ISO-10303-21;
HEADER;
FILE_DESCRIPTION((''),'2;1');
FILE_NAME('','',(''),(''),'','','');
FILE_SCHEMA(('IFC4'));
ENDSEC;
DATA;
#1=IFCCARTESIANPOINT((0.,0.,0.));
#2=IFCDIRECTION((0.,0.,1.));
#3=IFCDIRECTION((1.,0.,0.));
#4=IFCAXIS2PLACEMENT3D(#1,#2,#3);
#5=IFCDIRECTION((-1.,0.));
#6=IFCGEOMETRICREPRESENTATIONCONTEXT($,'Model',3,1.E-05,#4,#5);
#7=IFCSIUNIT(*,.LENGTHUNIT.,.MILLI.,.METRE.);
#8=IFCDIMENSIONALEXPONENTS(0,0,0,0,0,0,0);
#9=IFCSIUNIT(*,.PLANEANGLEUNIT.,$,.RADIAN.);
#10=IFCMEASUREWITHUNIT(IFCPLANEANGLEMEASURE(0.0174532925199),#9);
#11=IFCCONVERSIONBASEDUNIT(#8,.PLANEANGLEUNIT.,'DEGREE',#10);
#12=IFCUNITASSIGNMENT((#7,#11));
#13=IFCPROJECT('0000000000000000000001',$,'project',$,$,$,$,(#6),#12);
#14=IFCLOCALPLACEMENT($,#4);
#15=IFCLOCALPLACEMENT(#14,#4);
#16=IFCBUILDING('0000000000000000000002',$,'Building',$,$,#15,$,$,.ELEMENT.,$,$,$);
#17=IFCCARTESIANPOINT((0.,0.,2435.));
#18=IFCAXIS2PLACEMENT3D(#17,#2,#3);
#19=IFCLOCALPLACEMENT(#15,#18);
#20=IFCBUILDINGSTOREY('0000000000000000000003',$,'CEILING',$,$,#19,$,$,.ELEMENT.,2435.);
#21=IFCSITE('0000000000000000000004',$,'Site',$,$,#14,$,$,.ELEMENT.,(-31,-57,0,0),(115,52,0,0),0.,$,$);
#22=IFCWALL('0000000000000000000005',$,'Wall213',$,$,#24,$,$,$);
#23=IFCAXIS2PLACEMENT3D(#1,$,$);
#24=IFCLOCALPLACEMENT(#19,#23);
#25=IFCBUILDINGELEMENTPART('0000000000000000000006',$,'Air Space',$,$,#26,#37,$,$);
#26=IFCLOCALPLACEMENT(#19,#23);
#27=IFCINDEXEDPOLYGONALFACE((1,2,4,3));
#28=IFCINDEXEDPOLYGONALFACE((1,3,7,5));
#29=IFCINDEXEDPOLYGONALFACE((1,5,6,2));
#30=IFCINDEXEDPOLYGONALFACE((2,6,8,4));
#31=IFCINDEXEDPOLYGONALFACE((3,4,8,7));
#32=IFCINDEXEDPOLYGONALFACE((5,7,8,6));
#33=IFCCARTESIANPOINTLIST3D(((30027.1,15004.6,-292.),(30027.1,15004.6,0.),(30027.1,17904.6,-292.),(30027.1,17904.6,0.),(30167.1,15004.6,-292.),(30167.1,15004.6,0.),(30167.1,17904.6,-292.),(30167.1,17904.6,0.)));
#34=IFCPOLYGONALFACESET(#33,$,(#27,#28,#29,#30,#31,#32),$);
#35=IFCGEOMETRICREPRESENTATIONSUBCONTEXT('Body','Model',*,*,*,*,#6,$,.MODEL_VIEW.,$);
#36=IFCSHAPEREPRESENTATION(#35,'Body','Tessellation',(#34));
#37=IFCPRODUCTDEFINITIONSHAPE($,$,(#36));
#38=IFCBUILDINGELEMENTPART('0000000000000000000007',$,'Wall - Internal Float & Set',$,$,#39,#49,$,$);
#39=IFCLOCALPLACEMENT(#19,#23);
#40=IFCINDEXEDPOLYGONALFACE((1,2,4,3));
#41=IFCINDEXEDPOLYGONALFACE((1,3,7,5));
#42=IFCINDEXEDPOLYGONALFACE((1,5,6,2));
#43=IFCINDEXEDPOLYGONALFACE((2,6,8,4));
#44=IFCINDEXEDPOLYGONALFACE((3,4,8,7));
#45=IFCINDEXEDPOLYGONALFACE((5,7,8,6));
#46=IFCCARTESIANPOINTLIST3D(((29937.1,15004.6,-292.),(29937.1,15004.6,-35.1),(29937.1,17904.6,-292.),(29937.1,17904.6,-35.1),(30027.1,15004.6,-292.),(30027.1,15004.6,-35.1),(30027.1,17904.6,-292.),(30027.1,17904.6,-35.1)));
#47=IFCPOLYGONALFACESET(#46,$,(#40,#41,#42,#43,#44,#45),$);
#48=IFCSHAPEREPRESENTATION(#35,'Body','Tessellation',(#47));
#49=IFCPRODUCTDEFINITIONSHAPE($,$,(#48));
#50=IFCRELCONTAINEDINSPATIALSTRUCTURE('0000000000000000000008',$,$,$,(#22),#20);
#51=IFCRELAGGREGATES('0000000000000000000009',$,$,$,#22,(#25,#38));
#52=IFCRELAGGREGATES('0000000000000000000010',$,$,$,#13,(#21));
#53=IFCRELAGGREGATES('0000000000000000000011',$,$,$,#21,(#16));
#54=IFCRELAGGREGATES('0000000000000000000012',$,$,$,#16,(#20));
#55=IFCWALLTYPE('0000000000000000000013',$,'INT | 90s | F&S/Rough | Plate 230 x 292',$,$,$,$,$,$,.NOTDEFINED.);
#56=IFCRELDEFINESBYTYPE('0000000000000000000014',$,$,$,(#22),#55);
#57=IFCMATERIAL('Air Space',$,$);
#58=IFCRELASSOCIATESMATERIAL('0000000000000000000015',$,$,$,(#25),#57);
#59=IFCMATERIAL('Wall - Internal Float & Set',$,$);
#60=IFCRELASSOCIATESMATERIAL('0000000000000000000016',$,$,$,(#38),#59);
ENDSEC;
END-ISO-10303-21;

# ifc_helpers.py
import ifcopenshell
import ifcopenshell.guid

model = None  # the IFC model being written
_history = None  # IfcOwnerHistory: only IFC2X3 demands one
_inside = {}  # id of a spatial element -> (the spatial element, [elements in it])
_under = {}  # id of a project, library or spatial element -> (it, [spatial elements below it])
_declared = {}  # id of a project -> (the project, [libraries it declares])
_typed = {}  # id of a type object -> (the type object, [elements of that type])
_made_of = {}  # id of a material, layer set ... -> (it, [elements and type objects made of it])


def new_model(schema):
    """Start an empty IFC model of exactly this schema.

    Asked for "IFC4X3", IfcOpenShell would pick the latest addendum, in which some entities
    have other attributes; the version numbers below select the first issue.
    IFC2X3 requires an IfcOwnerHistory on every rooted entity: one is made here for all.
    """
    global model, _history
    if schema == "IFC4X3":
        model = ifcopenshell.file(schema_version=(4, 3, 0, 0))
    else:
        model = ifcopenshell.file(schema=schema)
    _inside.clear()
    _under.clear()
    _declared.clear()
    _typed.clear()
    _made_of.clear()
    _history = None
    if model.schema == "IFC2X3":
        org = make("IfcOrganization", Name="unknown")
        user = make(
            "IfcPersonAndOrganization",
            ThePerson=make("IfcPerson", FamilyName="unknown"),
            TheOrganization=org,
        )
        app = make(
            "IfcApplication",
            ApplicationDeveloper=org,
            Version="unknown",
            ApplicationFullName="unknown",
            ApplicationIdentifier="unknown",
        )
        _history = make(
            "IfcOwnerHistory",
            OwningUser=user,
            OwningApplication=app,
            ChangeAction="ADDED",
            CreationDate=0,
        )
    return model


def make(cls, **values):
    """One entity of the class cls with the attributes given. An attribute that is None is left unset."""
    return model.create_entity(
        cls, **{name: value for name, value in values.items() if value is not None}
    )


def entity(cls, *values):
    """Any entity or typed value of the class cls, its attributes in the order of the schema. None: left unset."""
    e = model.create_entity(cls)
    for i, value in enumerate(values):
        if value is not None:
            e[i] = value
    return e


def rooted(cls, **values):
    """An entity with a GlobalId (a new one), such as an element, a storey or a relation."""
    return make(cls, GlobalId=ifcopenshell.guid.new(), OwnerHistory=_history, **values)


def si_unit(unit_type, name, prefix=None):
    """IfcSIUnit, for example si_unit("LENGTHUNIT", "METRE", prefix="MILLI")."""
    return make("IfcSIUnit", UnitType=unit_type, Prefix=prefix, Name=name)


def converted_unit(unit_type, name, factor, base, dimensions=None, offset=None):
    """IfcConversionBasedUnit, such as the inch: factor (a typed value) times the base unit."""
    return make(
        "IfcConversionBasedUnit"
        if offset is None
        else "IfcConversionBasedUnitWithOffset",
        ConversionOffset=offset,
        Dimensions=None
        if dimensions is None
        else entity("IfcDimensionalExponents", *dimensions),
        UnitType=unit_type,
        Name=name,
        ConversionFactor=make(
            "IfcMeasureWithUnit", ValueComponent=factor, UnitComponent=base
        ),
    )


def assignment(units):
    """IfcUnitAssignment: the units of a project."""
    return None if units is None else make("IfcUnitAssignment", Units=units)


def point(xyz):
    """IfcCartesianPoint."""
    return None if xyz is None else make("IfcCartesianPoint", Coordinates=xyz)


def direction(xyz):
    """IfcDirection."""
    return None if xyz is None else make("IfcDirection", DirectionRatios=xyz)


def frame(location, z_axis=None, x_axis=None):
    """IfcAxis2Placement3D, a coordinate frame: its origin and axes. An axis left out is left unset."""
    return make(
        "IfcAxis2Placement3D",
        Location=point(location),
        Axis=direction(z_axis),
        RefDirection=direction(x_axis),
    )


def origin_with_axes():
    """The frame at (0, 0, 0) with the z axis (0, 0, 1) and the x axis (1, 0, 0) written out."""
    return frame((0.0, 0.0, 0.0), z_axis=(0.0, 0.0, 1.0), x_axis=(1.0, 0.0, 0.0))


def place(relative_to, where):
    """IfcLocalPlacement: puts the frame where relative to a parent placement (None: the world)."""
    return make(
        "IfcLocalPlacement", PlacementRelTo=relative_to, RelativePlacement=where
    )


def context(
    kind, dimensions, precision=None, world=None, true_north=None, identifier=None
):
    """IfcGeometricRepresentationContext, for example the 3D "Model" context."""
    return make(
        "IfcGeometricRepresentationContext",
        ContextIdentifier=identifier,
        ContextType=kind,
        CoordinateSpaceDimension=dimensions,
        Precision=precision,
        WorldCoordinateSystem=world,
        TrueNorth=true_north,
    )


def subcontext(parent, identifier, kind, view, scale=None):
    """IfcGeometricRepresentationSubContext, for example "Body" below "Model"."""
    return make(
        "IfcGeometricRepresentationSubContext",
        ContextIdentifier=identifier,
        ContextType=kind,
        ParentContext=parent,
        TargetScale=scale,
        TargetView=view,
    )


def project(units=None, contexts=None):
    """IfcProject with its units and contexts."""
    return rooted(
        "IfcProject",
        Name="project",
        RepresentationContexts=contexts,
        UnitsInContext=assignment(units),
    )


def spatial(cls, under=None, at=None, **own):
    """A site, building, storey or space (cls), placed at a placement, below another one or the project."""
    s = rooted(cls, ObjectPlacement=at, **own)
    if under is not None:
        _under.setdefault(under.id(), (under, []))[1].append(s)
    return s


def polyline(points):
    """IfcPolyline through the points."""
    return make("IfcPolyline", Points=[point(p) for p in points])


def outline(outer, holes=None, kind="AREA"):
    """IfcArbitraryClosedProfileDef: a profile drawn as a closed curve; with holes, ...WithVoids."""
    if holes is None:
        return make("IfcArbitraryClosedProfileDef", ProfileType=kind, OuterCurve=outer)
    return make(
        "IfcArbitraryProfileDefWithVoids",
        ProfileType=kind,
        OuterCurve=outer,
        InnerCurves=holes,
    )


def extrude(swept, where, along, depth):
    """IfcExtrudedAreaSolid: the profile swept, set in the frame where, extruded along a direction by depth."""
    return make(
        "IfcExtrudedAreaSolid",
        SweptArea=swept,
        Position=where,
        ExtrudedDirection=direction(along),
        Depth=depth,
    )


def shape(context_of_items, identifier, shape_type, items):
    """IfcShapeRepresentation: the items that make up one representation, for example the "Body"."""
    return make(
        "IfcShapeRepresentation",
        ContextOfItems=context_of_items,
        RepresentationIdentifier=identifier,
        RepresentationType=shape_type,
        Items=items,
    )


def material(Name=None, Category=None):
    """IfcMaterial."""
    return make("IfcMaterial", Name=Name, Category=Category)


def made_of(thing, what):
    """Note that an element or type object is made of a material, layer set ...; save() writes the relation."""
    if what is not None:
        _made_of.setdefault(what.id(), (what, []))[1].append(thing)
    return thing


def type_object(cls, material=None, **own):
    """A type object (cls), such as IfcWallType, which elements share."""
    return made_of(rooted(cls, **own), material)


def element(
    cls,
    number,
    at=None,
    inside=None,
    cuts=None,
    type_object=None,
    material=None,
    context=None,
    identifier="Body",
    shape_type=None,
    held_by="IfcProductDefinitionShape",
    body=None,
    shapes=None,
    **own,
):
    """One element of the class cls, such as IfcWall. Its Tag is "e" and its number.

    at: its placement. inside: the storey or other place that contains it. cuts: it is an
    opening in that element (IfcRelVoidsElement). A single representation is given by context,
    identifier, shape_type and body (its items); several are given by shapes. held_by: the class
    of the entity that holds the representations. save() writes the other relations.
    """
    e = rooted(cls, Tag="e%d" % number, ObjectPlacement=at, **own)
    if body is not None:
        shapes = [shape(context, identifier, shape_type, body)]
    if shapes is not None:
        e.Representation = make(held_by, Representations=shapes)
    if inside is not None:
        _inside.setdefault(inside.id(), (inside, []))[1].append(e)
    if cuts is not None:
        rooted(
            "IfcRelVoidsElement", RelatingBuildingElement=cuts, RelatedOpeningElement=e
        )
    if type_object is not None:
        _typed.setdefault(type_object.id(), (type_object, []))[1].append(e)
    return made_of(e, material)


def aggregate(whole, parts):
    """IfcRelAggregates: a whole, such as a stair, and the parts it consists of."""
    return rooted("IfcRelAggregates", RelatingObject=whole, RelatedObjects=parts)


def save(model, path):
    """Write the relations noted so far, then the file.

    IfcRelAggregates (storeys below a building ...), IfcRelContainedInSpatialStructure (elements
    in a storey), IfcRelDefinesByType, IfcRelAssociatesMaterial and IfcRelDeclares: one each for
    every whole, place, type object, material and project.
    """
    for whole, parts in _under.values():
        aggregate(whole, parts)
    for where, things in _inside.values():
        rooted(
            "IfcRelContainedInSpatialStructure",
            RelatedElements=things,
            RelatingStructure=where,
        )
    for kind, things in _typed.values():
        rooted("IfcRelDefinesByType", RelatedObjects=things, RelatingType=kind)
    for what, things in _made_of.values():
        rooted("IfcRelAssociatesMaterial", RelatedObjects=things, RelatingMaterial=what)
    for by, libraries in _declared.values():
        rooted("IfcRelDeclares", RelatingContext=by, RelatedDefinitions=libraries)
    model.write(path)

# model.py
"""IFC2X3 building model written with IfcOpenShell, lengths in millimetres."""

from ifc_helpers import new_model, entity, si_unit, converted_unit, direction, frame, origin_with_axes, place, context, subcontext, project, spatial, polyline, outline, extrude, material, type_object, element, aggregate, save


model = new_model("IFC2X3")

# Units and contexts
model_context = context("Model", 3, precision=1e-05, world=origin_with_axes(), true_north=direction((-1.0, 0.0)))
body_context = subcontext(model_context, "Body", "Model", "MODEL_VIEW")
ifc_project = project(units=[si_unit("LENGTHUNIT", "METRE", prefix="MILLI"), converted_unit("PLANEANGLEUNIT", "DEGREE", entity("IfcPlaneAngleMeasure", 0.0174532925199), si_unit("PLANEANGLEUNIT", "RADIAN"), dimensions=[0, 0, 0, 0, 0, 0, 0])], contexts=[model_context])

# Site, building, storey
site_placement = place(None, origin_with_axes())
site = spatial("IfcSite", under=ifc_project, at=site_placement, Name="Site", CompositionType="ELEMENT", RefLatitude=(-31, -57, 0, 0), RefLongitude=(115, 52, 0, 0), RefElevation=0.0)
building_placement = place(site_placement, origin_with_axes())
building = spatial("IfcBuilding", under=site, at=building_placement, Name="Building", CompositionType="ELEMENT")
storey_placement = place(building_placement, frame((0.0, 0.0, 2435.0), z_axis=(0.0, 0.0, 1.0), x_axis=(1.0, 0.0, 0.0)))
storey = spatial("IfcBuildingStorey", under=building, at=storey_placement, Name="CEILING", CompositionType="ELEMENT", Elevation=2435.0)

# Shared definitions
ifc_material_1 = material(Name="Air Space")

# Wall, building element parts
wall_type = type_object("IfcWallType", Name="INT | 90s | F&S/Rough | Plate 230 x 292", PredefinedType="NOTDEFINED")
ifc_material_2 = material(Name="Wall - Internal Float & Set")
wall_1_placement = place(storey_placement, frame((30027.1, 17904.6, -292.0), z_axis=(0.0, 0.0, 1.0), x_axis=(0.0, -1.0, 0.0)))
wall_1 = element("IfcWall", 1, at=wall_1_placement, inside=storey, type_object=wall_type, Name="Wall213")
building_element_part_1_placement = place(wall_1_placement, origin_with_axes())
building_element_part_1 = element("IfcBuildingElementPart", 2, at=building_element_part_1_placement, material=ifc_material_1, Name="Air Space", context=body_context, shape_type="SweptSolid", body=[
    extrude(outline(polyline([(0.0, 292.0), (0.0, 0.0), (140.0, 0.0), (140.0, 292.0), (0.0, 292.0)])), frame((0.0, 0.0, 0.0), z_axis=(1.0, 0.0, 0.0), x_axis=(0.0, 1.0, 0.0)), (0.0, 0.0, 1.0), 2900.0),
])
building_element_part_2_placement = place(wall_1_placement, origin_with_axes())
building_element_part_2 = element("IfcBuildingElementPart", 3, at=building_element_part_2_placement, material=ifc_material_2, Name="Wall - Internal Float & Set", context=body_context, shape_type="SweptSolid", body=[
    extrude(outline(polyline([(-90.0, 256.9), (-90.0, 0.0), (0.0, 0.0), (0.0, 256.9), (-90.0, 256.9)])), frame((0.0, 0.0, 0.0), z_axis=(1.0, 0.0, 0.0), x_axis=(0.0, 1.0, 0.0)), (0.0, 0.0, 1.0), 2900.0),
])
aggregate(wall_1, [building_element_part_1, building_element_part_2])

save(model, "model.ifc")
